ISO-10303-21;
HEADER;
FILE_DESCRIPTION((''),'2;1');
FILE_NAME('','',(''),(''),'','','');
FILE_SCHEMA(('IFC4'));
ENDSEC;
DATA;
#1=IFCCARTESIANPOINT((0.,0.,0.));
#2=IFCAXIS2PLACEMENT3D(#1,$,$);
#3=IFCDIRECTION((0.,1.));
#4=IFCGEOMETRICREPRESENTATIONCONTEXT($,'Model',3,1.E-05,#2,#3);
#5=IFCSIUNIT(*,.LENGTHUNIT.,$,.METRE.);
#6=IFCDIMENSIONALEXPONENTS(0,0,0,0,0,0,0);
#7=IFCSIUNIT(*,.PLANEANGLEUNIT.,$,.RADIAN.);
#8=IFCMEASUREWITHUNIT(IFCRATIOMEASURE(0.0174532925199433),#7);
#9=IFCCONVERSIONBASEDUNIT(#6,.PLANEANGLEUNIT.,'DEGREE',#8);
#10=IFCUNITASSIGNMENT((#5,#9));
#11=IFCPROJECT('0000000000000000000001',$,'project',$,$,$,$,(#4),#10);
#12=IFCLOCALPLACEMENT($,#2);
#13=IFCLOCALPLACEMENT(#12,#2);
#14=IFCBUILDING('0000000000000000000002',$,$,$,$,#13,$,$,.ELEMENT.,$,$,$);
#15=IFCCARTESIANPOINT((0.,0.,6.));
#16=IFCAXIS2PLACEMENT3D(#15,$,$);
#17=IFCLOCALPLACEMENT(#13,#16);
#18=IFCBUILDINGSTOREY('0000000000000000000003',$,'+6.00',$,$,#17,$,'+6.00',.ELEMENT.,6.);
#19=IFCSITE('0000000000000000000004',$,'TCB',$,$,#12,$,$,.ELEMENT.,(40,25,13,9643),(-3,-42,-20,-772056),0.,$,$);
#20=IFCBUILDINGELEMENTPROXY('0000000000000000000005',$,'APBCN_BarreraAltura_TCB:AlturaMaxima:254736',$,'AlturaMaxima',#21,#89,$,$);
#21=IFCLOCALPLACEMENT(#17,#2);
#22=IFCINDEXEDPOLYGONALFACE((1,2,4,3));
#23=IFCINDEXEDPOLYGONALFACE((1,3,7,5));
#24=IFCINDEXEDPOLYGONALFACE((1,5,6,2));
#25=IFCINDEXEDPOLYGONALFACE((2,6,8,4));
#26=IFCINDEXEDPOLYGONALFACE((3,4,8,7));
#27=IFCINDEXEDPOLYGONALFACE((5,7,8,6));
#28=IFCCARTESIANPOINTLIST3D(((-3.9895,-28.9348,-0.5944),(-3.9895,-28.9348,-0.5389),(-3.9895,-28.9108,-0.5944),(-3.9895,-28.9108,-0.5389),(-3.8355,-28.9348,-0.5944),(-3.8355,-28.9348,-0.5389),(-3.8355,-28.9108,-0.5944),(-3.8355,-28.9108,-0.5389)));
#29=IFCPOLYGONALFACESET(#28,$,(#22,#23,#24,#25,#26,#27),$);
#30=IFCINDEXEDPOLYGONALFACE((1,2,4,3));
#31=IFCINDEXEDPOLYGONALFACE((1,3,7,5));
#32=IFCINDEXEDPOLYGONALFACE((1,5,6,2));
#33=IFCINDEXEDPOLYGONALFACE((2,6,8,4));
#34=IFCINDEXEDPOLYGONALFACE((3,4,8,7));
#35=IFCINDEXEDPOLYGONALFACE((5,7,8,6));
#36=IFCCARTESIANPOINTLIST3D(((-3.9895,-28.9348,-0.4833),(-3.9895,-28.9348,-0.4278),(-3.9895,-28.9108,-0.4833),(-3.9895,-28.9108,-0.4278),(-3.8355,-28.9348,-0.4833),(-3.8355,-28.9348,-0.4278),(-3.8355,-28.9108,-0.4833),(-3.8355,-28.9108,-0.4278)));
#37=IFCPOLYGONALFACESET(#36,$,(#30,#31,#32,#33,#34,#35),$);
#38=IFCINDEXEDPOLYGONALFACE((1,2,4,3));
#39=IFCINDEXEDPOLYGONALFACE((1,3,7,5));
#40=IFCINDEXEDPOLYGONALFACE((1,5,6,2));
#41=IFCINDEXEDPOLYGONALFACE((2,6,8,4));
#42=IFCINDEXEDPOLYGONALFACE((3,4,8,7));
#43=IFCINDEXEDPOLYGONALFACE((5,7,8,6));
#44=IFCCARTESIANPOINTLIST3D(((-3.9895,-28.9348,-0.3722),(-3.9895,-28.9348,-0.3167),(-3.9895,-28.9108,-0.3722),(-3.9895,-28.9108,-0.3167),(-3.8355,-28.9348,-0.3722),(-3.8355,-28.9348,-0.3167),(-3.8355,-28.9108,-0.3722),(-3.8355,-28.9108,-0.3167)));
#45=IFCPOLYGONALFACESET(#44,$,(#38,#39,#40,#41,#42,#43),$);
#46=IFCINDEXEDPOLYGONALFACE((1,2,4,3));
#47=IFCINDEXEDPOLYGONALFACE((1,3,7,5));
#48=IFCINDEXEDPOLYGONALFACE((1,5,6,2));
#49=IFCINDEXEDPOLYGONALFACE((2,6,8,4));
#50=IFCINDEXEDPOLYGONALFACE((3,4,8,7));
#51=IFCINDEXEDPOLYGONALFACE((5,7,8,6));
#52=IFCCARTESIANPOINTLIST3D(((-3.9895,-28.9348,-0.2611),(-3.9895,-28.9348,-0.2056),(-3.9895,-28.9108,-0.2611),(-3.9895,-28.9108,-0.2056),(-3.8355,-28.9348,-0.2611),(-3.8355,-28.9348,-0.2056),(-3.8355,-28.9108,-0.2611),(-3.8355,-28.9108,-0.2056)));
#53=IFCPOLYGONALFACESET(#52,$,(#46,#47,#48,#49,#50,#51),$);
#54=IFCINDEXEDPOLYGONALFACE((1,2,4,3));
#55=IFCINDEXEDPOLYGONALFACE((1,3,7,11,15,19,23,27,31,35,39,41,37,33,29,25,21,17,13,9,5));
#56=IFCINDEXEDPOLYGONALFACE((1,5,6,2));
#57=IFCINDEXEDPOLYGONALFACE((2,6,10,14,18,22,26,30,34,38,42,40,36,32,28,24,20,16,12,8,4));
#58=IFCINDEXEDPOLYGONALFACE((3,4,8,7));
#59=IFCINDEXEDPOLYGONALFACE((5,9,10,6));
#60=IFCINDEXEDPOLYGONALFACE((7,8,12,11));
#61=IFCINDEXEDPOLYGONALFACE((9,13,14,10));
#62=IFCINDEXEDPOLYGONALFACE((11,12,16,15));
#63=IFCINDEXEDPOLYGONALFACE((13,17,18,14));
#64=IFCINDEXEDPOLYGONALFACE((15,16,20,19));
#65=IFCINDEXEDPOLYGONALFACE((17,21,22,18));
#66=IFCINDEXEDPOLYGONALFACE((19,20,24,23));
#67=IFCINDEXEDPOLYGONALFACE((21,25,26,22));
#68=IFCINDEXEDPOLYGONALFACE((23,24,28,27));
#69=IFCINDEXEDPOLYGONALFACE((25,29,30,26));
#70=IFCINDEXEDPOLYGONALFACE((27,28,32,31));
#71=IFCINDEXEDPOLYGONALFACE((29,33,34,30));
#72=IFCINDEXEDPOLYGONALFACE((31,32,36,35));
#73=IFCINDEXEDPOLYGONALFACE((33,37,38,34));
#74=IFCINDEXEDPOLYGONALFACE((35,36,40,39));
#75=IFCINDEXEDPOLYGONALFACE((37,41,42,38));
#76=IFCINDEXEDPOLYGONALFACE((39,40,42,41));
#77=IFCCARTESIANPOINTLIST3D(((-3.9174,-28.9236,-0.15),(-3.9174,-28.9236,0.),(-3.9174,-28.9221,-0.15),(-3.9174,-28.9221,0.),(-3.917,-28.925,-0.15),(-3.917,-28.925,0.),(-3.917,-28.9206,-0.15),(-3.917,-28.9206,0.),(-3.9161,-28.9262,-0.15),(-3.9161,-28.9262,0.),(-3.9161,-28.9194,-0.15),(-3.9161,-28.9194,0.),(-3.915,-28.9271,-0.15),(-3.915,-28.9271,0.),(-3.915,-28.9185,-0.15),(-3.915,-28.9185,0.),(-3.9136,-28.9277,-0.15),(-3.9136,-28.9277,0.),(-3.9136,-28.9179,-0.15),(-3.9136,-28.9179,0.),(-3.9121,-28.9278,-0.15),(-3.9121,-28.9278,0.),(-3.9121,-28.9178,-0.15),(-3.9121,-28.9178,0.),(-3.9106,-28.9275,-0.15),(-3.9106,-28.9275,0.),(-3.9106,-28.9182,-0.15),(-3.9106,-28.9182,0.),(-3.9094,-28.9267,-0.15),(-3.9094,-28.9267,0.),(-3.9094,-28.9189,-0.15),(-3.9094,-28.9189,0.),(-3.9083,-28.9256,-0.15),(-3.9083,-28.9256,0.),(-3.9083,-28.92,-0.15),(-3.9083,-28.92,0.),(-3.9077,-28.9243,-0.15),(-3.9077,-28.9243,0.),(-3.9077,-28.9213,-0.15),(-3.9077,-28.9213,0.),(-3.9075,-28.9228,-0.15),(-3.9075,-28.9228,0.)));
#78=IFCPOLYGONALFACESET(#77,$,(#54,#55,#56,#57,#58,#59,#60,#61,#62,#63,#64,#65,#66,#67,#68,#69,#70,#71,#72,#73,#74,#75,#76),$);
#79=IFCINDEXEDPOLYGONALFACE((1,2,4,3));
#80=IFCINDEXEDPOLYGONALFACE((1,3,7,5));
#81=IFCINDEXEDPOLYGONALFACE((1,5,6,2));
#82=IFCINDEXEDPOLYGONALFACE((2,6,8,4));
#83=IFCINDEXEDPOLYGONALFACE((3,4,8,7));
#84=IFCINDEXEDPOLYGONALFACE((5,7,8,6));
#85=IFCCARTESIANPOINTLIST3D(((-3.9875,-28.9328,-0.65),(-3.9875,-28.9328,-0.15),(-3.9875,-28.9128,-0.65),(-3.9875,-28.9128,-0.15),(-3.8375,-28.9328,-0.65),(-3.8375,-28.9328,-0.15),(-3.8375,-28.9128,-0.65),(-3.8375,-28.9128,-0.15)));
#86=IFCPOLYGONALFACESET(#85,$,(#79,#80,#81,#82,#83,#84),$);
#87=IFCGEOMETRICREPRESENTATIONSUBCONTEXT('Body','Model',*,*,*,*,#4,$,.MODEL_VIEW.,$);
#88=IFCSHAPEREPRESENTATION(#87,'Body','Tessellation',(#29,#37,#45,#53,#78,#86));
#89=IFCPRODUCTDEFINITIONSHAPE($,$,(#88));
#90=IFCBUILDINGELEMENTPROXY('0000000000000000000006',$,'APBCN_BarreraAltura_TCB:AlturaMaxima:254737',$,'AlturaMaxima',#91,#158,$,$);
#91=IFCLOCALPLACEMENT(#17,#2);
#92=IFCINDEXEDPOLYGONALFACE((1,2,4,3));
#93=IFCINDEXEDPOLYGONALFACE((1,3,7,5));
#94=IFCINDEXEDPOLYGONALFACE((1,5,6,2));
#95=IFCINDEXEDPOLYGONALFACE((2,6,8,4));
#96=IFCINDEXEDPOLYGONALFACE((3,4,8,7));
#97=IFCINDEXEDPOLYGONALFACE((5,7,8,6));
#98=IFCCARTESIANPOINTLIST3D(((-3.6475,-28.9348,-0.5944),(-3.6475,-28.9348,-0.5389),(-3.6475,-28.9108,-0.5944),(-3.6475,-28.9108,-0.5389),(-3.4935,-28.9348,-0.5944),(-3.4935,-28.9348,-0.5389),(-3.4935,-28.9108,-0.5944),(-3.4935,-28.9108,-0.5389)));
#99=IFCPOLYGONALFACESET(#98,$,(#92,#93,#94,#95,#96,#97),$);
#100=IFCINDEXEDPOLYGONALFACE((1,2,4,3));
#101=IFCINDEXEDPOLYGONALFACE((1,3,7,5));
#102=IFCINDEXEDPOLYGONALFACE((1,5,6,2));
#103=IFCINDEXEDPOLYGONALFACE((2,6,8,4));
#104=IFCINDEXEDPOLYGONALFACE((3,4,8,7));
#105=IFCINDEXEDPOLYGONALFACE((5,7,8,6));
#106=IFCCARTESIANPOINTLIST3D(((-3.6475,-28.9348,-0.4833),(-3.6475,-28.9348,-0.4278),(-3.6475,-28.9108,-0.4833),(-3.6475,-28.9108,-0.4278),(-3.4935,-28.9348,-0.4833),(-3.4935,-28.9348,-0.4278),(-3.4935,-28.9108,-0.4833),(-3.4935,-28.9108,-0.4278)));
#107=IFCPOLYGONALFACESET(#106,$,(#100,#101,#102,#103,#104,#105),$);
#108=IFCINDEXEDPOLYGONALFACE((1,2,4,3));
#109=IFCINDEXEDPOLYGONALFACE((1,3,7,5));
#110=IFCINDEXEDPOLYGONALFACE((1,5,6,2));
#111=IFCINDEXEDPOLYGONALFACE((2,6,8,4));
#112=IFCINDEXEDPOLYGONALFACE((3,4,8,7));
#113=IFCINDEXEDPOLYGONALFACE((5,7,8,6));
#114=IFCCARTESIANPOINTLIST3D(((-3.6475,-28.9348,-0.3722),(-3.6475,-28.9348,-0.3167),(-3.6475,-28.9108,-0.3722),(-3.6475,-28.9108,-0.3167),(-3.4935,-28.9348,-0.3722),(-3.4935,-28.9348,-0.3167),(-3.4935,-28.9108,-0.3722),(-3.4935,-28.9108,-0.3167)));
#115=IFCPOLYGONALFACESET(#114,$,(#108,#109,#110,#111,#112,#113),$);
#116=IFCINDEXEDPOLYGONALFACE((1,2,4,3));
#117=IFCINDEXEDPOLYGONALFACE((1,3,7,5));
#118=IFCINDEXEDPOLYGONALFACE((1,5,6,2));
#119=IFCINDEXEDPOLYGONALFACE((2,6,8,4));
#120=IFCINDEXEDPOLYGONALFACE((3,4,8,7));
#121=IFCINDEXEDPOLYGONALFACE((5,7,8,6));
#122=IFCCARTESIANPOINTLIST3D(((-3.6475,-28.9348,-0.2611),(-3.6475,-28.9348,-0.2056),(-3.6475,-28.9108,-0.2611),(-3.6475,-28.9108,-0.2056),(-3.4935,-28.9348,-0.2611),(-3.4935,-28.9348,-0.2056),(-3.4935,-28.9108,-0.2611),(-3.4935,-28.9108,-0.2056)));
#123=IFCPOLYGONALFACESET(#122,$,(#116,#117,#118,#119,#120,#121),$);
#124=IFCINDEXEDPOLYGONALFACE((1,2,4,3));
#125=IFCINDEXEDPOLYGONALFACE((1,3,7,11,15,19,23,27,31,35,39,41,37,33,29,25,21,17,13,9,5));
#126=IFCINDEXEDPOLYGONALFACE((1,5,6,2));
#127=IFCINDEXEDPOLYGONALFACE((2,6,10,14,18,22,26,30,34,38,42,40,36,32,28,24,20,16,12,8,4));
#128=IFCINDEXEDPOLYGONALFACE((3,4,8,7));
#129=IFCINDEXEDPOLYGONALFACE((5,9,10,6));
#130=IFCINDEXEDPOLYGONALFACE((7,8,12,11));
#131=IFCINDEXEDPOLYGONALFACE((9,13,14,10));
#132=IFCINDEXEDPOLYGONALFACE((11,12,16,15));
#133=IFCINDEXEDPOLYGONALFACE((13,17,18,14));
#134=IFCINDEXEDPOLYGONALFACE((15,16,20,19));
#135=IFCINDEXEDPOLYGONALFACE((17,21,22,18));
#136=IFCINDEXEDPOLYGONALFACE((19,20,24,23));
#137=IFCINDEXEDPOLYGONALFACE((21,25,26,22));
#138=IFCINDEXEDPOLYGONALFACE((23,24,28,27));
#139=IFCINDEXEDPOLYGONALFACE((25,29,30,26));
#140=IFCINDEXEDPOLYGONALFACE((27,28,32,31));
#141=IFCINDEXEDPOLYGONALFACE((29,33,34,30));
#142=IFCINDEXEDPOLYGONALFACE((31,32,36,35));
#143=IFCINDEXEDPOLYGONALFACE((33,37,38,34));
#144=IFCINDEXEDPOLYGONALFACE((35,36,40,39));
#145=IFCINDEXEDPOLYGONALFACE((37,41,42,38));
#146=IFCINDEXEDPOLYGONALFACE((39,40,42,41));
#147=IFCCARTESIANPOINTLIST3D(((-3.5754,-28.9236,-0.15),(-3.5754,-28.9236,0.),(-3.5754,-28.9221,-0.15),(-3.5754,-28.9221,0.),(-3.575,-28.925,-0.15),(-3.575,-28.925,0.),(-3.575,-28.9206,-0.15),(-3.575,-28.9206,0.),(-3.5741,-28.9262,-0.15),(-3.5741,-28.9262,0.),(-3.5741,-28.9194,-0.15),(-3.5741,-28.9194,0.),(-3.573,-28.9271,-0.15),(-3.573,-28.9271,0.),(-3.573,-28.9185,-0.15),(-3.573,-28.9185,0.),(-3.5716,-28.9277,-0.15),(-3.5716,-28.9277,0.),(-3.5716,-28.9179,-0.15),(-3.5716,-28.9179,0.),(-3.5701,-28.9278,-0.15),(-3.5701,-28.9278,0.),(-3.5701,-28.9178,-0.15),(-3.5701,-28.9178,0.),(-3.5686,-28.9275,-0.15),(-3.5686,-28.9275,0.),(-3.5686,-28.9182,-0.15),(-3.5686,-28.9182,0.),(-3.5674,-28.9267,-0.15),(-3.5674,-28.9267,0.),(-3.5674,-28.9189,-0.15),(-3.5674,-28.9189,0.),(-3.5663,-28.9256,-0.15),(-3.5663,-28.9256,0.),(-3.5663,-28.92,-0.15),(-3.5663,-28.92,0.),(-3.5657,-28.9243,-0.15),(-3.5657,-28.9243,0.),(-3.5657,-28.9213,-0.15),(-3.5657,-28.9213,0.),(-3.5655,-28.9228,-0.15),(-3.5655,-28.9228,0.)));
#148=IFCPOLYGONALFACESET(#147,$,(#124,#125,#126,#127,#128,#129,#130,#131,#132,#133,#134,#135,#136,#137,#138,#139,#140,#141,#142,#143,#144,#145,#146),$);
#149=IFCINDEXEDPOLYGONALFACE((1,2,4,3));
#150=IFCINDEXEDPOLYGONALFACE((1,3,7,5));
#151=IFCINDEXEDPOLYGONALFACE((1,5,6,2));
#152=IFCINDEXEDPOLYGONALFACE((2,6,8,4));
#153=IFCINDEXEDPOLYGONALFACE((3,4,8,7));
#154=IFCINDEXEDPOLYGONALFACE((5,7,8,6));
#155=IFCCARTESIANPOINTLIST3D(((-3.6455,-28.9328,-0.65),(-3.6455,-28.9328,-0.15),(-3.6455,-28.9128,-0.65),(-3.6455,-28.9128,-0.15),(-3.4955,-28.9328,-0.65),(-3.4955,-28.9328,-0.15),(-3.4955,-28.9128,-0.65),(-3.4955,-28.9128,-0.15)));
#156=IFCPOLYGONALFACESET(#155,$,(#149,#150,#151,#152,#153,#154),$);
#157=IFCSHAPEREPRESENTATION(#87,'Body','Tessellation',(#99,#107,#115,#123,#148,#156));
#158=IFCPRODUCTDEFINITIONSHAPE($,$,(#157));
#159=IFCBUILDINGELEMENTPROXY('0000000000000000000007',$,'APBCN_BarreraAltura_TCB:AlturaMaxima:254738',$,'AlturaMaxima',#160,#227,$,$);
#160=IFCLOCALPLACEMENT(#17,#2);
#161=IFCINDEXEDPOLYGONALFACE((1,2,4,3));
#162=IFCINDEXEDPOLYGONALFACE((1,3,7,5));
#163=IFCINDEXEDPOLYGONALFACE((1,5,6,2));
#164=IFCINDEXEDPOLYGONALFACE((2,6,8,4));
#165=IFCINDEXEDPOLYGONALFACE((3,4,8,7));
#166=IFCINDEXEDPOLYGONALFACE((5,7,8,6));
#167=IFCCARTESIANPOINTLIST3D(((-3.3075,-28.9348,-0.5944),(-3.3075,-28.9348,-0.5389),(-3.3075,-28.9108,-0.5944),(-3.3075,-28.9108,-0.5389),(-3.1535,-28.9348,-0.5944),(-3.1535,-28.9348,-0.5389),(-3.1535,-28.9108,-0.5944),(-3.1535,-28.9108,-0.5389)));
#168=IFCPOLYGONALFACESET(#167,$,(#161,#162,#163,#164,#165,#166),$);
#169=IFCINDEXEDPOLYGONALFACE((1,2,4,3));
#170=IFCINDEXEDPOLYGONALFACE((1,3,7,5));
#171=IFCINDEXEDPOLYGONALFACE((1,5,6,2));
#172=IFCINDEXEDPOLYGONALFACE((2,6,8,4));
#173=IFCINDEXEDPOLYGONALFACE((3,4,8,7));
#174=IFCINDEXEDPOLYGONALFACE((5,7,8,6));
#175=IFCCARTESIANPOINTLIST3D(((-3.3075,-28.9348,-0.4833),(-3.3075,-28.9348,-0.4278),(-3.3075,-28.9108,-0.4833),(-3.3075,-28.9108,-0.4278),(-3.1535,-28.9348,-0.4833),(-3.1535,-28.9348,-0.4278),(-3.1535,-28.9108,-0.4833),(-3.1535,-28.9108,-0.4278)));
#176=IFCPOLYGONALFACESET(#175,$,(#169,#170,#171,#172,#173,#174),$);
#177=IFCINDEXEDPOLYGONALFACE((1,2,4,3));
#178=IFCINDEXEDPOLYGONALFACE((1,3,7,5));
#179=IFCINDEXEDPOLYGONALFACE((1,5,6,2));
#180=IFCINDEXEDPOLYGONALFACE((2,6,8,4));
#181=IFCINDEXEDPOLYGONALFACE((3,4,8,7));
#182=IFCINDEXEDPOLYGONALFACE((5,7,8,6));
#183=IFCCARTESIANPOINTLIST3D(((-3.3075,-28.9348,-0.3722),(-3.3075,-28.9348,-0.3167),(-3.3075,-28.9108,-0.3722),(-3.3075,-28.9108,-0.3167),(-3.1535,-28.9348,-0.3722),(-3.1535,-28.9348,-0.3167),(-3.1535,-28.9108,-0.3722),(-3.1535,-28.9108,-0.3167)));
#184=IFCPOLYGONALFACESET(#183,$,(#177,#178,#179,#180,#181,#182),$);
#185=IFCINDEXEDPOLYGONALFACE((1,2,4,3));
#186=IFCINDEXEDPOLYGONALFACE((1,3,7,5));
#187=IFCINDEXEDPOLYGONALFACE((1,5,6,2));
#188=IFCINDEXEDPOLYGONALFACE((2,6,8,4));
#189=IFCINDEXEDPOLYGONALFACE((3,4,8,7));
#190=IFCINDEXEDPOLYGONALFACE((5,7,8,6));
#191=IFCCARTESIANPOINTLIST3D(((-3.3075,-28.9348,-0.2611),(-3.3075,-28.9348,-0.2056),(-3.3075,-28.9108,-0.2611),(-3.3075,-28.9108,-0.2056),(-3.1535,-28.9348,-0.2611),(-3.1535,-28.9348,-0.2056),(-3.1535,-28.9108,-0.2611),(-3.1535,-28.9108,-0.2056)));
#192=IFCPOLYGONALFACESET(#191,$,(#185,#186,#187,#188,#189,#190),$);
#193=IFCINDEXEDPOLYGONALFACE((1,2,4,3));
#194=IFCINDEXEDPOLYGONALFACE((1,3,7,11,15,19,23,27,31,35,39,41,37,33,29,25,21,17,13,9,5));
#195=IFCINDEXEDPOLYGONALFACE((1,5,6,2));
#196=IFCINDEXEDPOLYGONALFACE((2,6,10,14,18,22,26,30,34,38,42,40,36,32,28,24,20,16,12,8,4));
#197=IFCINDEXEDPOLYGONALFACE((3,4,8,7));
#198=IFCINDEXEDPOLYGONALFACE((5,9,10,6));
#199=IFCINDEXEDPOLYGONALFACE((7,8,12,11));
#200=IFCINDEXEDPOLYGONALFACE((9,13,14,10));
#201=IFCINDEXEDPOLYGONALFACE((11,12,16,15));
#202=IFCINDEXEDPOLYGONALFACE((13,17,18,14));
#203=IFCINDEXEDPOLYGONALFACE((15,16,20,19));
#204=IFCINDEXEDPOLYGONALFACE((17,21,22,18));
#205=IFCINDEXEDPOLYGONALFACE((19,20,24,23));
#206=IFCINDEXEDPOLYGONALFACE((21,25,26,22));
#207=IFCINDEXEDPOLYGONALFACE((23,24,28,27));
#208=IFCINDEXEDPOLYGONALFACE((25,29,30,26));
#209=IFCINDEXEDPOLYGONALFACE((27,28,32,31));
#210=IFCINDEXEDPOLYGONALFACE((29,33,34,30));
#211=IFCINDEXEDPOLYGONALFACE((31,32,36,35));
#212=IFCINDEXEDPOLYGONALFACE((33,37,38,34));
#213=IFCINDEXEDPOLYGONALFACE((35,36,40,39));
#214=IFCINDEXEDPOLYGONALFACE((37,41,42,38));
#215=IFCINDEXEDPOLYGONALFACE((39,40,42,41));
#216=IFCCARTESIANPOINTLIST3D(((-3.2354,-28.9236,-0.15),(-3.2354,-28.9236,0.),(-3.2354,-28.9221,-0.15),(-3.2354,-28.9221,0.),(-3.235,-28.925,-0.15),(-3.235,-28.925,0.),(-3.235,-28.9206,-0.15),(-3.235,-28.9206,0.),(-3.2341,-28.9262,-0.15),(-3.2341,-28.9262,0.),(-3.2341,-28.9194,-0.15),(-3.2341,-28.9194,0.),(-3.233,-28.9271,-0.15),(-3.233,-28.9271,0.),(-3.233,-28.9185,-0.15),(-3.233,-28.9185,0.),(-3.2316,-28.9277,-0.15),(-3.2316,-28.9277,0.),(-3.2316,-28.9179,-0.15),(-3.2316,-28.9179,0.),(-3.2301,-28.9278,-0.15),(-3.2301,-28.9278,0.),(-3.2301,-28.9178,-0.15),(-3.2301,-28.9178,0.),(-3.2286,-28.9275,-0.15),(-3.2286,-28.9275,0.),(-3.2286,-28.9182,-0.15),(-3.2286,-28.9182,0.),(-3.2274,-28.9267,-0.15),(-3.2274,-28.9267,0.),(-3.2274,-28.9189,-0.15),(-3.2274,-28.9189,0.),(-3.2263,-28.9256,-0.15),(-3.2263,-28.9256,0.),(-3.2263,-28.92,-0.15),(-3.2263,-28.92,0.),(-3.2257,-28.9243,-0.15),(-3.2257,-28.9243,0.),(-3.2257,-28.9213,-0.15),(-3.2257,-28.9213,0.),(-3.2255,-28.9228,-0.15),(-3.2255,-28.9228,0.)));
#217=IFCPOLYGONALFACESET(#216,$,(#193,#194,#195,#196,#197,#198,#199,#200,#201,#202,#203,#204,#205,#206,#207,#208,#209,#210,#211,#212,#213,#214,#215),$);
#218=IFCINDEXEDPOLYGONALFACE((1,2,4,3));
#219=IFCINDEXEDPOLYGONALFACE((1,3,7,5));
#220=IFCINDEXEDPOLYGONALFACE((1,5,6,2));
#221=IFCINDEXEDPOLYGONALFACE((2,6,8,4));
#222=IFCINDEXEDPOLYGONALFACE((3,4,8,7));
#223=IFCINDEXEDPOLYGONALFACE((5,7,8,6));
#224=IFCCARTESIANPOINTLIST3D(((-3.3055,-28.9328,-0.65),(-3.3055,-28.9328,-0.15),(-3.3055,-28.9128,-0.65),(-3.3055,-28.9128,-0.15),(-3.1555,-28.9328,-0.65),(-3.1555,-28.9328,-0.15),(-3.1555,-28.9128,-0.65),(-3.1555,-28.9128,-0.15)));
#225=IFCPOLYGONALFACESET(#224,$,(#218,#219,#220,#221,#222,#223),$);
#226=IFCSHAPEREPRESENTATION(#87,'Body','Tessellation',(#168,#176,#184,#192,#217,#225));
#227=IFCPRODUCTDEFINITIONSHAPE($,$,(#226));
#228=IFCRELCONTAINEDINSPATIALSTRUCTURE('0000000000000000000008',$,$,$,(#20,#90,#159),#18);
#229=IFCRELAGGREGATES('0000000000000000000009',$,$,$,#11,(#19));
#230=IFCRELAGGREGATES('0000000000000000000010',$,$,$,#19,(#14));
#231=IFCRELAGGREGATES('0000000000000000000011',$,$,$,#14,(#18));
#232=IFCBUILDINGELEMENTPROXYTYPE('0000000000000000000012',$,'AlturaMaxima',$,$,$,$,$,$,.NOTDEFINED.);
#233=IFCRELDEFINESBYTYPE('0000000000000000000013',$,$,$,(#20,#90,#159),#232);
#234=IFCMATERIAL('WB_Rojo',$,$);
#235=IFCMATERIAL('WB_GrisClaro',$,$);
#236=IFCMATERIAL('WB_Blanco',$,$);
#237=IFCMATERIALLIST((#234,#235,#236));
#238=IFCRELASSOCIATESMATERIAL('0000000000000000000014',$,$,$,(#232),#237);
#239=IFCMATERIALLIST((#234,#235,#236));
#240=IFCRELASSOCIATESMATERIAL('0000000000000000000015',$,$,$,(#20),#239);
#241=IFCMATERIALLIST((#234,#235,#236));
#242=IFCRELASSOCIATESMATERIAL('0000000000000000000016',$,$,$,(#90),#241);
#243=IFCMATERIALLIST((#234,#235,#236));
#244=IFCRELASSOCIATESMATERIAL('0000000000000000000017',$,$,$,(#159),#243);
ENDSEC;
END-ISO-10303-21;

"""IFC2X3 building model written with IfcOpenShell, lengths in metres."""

from ifc_helpers import new_model, entity, si_unit, converted_unit, direction, frame, frame_2d, origin, origin_2d_with_axis, place, context, subcontext, project, spatial, rectangle, circle, extrude, source, transform, mapped, material, material_list, type_object, type_shapes, element, save


model = new_model("IFC2X3")

# Units and contexts
model_context = context("Model", 3, precision=1e-05, world=origin(), true_north=direction((0.0, 1.0)))
body_context = subcontext(model_context, "Body", "Model", "MODEL_VIEW")
ifc_project = project(units=[si_unit("LENGTHUNIT", "METRE"), converted_unit("PLANEANGLEUNIT", "DEGREE", entity("IfcRatioMeasure", 0.0174532925199433), si_unit("PLANEANGLEUNIT", "RADIAN"), dimensions=[0, 0, 0, 0, 0, 0, 0])], contexts=[model_context])

# Site, building, storey
site_placement = place(None, origin())
site = spatial("IfcSite", under=ifc_project, at=site_placement, Name="TCB", CompositionType="ELEMENT", RefLatitude=(40, 25, 13, 9643), RefLongitude=(-3, -42, -20, -772056), RefElevation=0.0)
building_placement = place(site_placement, origin())
building = spatial("IfcBuilding", under=site, at=building_placement, CompositionType="ELEMENT")
storey_placement = place(building_placement, frame((0.0, 0.0, 6.0)))
storey = spatial("IfcBuildingStorey", under=building, at=storey_placement, Name="+6.00", LongName="+6.00", CompositionType="ELEMENT", Elevation=6.0)

# Building element proxies
ifc_material_1 = material(Name="WB_Rojo")
ifc_material_2 = material(Name="WB_GrisClaro")
ifc_material_3 = material(Name="WB_Blanco")
ifc_material_list_1 = material_list([ifc_material_1, ifc_material_2, ifc_material_3])
building_element_proxy_type = type_object("IfcBuildingElementProxyType", Name="AlturaMaxima", PredefinedType="NOTDEFINED", material=ifc_material_list_1)
shared_shape = source(origin(), body_context, "Body", "SweptSolid", [
    extrude(rectangle(XDim=0.154, YDim=0.024, at=frame_2d((0.0, 0.0), x_axis=(1.0, 0.0))), frame((0.0, 0.0, -0.5944), z_axis=(0.0, 0.0, 1.0), x_axis=(-1.0, 0.0, 0.0)), (0.0, 0.0, 1.0), 0.0556),
    extrude(rectangle(XDim=0.154, YDim=0.024, at=frame_2d((0.0, 0.0), x_axis=(1.0, 0.0))), frame((0.0, 0.0, -0.4833), z_axis=(0.0, 0.0, 1.0), x_axis=(-1.0, 0.0, 0.0)), (0.0, 0.0, 1.0), 0.0556),
    extrude(rectangle(XDim=0.154, YDim=0.024, at=frame_2d((0.0, 0.0), x_axis=(1.0, 0.0))), frame((0.0, 0.0, -0.3722), z_axis=(0.0, 0.0, 1.0), x_axis=(-1.0, 0.0, 0.0)), (0.0, 0.0, 1.0), 0.0556),
    extrude(rectangle(XDim=0.154, YDim=0.024, at=frame_2d((0.0, 0.0), x_axis=(1.0, 0.0))), frame((0.0, 0.0, -0.2611), z_axis=(0.0, 0.0, 1.0), x_axis=(-1.0, 0.0, 0.0)), (0.0, 0.0, 1.0), 0.0556),
    extrude(circle(Radius=0.005, at=frame_2d((0.0, 0.0), x_axis=(1.0, 0.0))), frame((0.0, 0.0, -0.15)), (0.0, 0.0, 1.0), 0.15),
    extrude(rectangle(XDim=0.02, YDim=0.15, at=origin_2d_with_axis()), frame((0.0, 0.0, -0.65), z_axis=(0.0, 0.0, 1.0), x_axis=(0.0, 1.0, 0.0)), (0.0, 0.0, 1.0), 0.5),
])
type_shapes(building_element_proxy_type, [shared_shape])
ifc_material_list_2 = material_list([ifc_material_1, ifc_material_2, ifc_material_3])
proxy_1_placement = place(storey_placement, frame((-3.9125, -28.9228, 0.0)))
element("IfcBuildingElementProxy", 1, at=proxy_1_placement, inside=storey, type_object=building_element_proxy_type, material=ifc_material_list_2, Name="APBCN_BarreraAltura_TCB:AlturaMaxima:254736", ObjectType="AlturaMaxima", context=body_context, shape_type="MappedRepresentation", body=[
    mapped(shared_shape, transform((0.0, 0.0, 0.0), scale=1.0)),
])
ifc_material_list_3 = material_list([ifc_material_1, ifc_material_2, ifc_material_3])
proxy_2_placement = place(storey_placement, frame((-3.5705, -28.9228, 0.0)))
element("IfcBuildingElementProxy", 2, at=proxy_2_placement, inside=storey, type_object=building_element_proxy_type, material=ifc_material_list_3, Name="APBCN_BarreraAltura_TCB:AlturaMaxima:254737", ObjectType="AlturaMaxima", context=body_context, shape_type="MappedRepresentation", body=[
    mapped(shared_shape, transform((0.0, 0.0, 0.0), scale=1.0)),
])
ifc_material_list_4 = material_list([ifc_material_1, ifc_material_2, ifc_material_3])
proxy_3_placement = place(storey_placement, frame((-3.2305, -28.9228, 0.0)))
element("IfcBuildingElementProxy", 3, at=proxy_3_placement, inside=storey, type_object=building_element_proxy_type, material=ifc_material_list_4, Name="APBCN_BarreraAltura_TCB:AlturaMaxima:254738", ObjectType="AlturaMaxima", context=body_context, shape_type="MappedRepresentation", body=[
    mapped(shared_shape, transform((0.0, 0.0, 0.0), scale=1.0)),
])

save(model, "model.ifc")
